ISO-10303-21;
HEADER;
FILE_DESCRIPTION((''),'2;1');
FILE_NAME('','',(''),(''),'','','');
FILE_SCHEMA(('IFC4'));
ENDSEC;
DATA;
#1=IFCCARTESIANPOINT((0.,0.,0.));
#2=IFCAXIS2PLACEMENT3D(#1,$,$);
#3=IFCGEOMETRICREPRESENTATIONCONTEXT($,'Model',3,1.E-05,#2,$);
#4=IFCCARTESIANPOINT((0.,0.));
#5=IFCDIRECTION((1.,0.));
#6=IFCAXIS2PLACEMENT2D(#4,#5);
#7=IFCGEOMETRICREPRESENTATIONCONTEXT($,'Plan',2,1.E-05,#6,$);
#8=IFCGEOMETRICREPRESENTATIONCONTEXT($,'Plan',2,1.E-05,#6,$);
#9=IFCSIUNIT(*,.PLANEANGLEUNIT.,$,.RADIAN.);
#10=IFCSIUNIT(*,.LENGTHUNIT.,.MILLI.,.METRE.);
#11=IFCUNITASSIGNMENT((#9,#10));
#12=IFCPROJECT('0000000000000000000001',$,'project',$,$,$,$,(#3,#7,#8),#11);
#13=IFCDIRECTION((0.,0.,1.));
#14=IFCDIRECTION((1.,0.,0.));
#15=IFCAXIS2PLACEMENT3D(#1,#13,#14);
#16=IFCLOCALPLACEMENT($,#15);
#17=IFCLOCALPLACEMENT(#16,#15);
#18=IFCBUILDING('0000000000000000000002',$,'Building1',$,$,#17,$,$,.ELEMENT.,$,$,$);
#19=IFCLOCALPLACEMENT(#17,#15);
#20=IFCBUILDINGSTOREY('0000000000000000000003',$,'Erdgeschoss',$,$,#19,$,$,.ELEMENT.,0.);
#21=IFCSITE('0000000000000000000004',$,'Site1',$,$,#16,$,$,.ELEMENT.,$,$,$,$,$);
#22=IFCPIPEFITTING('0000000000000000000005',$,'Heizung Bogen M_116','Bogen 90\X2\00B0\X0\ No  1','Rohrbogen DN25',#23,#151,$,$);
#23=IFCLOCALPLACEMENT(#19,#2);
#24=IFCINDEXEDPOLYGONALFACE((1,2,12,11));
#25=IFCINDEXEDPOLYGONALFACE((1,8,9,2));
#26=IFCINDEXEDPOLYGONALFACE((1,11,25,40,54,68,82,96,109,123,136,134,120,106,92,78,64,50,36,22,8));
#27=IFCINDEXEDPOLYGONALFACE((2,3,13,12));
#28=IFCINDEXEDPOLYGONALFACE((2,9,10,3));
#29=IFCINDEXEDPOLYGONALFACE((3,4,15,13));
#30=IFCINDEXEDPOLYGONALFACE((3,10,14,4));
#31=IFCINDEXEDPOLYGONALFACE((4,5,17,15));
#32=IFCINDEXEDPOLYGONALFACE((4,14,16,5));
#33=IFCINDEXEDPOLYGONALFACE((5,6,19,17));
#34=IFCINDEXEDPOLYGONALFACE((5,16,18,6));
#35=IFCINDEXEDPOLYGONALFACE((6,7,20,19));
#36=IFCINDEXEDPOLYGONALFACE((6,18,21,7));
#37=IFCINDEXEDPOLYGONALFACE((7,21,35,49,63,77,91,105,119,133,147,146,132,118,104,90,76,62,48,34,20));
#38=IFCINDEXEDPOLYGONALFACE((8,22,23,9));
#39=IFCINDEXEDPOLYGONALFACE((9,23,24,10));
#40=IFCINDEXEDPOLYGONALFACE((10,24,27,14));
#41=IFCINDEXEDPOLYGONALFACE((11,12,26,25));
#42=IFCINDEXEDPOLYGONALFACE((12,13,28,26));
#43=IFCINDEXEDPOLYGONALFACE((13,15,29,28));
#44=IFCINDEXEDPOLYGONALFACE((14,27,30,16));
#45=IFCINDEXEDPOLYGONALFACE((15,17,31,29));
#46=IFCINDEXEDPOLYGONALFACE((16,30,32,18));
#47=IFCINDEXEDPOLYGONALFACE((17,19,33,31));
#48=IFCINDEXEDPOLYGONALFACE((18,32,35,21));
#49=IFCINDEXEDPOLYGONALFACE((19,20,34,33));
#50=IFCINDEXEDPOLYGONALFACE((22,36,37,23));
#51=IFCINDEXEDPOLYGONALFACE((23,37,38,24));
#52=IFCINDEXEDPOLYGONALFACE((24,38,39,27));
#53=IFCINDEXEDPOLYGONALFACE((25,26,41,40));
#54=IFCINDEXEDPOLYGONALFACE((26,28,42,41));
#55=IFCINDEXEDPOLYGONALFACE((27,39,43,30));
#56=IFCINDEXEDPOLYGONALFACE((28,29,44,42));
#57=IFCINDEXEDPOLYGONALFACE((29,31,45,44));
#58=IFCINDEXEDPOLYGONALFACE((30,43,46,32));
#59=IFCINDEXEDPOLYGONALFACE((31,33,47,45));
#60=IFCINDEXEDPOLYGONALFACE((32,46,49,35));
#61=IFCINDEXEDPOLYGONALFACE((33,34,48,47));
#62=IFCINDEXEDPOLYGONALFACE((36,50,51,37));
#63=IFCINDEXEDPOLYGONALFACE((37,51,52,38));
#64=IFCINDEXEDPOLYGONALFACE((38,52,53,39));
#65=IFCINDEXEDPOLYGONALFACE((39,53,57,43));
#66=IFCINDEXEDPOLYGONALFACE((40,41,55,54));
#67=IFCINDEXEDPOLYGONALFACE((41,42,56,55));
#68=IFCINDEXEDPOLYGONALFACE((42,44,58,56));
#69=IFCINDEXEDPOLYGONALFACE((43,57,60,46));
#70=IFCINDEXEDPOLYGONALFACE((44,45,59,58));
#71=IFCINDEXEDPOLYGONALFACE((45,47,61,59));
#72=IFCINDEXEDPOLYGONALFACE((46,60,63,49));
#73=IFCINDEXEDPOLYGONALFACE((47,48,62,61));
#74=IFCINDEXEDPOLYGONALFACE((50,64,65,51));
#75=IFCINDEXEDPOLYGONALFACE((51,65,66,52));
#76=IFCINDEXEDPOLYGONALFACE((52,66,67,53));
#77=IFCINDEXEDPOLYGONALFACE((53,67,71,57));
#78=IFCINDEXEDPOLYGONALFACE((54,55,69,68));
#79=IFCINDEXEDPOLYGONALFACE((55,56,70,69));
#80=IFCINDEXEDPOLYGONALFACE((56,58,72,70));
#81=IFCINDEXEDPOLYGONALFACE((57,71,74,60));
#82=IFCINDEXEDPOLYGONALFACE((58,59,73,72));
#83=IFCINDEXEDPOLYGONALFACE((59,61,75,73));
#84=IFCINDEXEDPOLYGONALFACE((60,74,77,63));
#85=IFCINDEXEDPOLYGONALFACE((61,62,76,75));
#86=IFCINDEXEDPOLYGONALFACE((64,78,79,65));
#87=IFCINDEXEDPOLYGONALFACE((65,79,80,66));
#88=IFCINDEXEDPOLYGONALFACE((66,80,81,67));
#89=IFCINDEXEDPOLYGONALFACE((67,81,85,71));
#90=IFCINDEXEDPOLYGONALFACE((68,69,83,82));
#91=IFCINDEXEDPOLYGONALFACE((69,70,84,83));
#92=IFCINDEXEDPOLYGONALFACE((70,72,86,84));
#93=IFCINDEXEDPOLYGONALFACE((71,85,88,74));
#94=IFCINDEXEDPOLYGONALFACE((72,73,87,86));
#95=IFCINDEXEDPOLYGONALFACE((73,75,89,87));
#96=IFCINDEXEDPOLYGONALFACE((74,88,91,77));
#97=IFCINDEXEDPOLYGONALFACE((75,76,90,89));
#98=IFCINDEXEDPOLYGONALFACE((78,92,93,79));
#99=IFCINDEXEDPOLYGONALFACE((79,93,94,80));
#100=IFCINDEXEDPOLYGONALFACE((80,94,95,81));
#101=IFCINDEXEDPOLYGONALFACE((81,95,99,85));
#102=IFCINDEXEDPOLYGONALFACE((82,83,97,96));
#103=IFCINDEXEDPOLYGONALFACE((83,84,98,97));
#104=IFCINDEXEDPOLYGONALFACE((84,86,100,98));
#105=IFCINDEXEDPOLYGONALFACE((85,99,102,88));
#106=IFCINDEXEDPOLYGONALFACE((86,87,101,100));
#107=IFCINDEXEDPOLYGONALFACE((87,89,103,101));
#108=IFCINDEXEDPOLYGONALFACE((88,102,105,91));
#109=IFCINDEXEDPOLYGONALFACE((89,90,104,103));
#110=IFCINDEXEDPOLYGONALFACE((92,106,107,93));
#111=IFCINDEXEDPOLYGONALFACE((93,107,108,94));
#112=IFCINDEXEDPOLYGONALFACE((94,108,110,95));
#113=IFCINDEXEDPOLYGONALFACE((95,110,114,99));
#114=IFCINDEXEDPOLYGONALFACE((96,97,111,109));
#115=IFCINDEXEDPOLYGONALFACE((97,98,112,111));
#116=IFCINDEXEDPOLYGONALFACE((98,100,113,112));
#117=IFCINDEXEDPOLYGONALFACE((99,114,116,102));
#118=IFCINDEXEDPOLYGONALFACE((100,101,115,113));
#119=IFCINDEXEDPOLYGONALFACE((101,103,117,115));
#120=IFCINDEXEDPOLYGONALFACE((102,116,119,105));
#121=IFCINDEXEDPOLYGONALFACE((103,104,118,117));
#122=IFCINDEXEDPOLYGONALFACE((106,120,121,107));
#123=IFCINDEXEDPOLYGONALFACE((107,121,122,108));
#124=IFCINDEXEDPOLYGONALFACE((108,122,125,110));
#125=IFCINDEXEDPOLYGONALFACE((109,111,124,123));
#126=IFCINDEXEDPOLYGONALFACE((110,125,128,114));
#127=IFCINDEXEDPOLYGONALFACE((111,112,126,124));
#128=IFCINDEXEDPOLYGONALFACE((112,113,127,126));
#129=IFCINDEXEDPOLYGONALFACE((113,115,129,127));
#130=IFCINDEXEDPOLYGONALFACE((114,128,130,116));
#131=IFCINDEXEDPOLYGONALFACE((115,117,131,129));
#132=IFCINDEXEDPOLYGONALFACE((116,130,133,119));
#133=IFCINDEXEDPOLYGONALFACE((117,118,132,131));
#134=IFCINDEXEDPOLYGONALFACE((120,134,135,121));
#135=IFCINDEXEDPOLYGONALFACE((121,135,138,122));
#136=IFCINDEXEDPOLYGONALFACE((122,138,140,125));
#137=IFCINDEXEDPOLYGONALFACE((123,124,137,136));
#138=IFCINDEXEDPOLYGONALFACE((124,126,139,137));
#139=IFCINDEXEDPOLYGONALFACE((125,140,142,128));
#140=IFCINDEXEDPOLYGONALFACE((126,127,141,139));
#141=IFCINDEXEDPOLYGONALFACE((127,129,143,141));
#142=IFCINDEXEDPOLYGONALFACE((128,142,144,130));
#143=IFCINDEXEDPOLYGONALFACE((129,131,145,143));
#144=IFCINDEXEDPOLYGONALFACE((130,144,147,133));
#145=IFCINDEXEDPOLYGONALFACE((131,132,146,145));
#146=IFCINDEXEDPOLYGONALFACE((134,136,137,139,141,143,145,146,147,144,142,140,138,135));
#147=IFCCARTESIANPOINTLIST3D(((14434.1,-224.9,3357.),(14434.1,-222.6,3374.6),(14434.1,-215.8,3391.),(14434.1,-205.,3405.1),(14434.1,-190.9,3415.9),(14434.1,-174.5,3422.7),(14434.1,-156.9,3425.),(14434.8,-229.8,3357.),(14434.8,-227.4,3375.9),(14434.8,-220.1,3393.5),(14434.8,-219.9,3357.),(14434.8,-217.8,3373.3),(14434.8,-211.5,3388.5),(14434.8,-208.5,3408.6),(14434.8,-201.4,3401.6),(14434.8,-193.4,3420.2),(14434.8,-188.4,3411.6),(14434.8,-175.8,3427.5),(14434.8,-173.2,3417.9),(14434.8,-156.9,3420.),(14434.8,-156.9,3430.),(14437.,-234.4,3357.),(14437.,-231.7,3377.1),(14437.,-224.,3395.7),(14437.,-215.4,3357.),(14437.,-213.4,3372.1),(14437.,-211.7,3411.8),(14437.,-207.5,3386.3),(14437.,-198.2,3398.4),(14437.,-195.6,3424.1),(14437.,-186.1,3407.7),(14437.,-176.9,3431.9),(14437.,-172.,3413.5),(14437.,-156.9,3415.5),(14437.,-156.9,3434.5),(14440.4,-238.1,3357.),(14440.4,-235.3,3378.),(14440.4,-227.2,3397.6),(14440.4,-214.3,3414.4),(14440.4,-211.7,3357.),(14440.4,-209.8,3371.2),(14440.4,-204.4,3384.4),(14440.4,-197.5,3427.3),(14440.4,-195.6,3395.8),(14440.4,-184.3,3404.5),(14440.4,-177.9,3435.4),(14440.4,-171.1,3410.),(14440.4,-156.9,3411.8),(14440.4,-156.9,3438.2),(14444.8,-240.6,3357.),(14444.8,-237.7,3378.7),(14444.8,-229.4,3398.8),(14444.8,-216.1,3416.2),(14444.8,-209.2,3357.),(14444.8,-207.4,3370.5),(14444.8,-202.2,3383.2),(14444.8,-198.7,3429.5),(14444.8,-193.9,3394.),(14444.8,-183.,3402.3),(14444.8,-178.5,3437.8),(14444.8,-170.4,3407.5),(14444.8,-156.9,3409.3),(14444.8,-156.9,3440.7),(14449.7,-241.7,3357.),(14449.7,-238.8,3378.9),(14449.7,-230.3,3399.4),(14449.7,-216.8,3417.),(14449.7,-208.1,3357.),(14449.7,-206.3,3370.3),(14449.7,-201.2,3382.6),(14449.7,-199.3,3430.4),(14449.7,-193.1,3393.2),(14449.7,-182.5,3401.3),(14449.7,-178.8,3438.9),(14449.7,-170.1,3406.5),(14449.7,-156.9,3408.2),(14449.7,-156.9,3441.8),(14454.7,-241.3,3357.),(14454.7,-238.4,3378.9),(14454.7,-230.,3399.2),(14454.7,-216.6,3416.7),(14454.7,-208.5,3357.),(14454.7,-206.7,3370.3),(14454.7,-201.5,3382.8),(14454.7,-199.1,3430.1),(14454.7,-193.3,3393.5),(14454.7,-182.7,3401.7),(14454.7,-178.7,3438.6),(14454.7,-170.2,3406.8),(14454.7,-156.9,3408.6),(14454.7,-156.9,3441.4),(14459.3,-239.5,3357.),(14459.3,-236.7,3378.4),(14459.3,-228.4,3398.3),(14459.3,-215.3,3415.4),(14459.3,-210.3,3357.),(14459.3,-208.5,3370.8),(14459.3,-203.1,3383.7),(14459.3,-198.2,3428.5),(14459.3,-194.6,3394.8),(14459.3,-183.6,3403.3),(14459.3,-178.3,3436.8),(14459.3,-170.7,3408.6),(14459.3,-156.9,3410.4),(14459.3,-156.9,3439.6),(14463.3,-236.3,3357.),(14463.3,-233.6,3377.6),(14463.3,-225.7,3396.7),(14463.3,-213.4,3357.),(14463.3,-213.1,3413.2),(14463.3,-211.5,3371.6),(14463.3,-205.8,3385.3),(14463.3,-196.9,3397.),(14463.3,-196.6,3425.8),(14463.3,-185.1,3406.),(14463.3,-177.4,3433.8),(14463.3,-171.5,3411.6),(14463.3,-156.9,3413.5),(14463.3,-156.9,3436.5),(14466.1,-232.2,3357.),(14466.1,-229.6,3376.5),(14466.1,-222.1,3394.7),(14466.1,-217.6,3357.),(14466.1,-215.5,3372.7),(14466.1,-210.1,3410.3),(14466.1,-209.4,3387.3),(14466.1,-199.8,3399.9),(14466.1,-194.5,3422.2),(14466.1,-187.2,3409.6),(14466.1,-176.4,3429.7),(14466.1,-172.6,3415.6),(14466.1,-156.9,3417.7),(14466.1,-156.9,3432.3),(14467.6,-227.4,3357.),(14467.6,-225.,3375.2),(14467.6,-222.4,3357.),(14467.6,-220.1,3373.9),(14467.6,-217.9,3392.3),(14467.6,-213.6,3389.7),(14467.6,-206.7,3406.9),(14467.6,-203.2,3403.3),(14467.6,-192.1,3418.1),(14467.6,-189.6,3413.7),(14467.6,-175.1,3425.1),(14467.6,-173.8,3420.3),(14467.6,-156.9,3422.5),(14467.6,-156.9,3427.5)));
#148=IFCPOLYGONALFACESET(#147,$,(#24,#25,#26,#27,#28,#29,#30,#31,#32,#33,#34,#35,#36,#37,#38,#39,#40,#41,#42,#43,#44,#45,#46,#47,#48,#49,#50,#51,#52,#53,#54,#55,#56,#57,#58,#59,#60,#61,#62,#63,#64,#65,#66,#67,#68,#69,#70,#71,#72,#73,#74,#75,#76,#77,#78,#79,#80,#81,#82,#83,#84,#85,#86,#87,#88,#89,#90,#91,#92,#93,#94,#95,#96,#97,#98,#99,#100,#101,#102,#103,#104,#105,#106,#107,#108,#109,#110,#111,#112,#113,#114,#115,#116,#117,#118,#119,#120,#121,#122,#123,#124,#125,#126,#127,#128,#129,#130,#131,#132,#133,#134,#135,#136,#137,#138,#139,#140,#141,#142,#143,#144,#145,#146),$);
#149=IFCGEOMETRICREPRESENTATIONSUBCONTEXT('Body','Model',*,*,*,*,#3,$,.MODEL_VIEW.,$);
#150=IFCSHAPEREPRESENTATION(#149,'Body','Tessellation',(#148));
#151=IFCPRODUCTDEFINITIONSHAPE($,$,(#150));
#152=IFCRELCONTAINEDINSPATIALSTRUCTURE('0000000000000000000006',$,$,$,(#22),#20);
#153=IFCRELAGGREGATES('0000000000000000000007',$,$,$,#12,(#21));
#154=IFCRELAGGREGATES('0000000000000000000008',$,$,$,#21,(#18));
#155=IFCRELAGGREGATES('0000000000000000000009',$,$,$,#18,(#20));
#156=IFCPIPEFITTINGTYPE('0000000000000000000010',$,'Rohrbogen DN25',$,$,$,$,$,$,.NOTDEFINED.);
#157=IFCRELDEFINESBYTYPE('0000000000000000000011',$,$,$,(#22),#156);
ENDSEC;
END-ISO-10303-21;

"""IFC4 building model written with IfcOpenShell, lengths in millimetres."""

from ifc_helpers import new_model, entity, si_unit, frame, origin, origin_with_axes, origin_2d_with_axis, place, context, subcontext, project, spatial, shape, source, transform, mapped, type_object, element, save


model = new_model("IFC4")

# Units and contexts
model_context = context("Model", 3, precision=1e-05, world=origin())
plan_context_1 = context("Plan", 2, precision=1e-05, world=origin_2d_with_axis())
plan_context_2 = context("Plan", 2, precision=1e-05, world=origin_2d_with_axis())
body_context = subcontext(model_context, "Body", "Model", "MODEL_VIEW")
ifc_project = project(units=[si_unit("PLANEANGLEUNIT", "RADIAN"), si_unit("LENGTHUNIT", "METRE", prefix="MILLI")], contexts=[model_context, plan_context_1, plan_context_2])

# Site, building, storey
site_placement = place(None, origin_with_axes())
site = spatial("IfcSite", under=ifc_project, at=site_placement, Name="Site1", CompositionType="ELEMENT")
building_placement = place(site_placement, origin_with_axes())
building = spatial("IfcBuilding", under=site, at=building_placement, Name="Building1", CompositionType="ELEMENT")
storey_placement = place(building_placement, origin_with_axes())
storey = spatial("IfcBuildingStorey", under=building, at=storey_placement, Name="Erdgeschoss", CompositionType="ELEMENT", Elevation=0.0)

# Pipe fitting
pipe_fitting_type = type_object("IfcPipeFittingType", Name="Rohrbogen DN25", PredefinedType="NOTDEFINED")
shared_shape_1 = source(origin_with_axes(), body_context, "Body", "SolidModel", [
    entity("IfcRevolvedAreaSolid", entity("IfcCircleProfileDef", "AREA", None, entity("IfcAxis2Placement2D", entity("IfcCartesianPoint", [0.0, 0.0]), entity("IfcDirection", [1.0, 0.0])), 16.9), entity("IfcAxis2Placement3D", entity("IfcCartesianPoint", [-42.4, 0.0, 25.6]), entity("IfcDirection", [1.0, 0.0, 0.0]), entity("IfcDirection", [0.0, -1.0, 0.0])), entity("IfcAxis1Placement", entity("IfcCartesianPoint", [0.0, 68.0, 0.0]), entity("IfcDirection", [-1.0, 0.0, 0.0])), 1.570796),
])
pipe_fitting_1_placement = place(storey_placement, frame((14450.9, -199.3, 3399.4), z_axis=(0.0, 0.0, 1.0), x_axis=(1.0, 0.0, 0.0)))
element("IfcPipeFitting", 1, at=pipe_fitting_1_placement, inside=storey, type_object=pipe_fitting_type, Name="Heizung Bogen M_116", Description="Bogen 90° No  1", ObjectType="Rohrbogen DN25", shapes=[
    shape(body_context, "Body", "MappedRepresentation", [mapped(shared_shape_1, transform((0.0, 0.0, 0.0), x_axis=(0.0, -1.0, 0.0), y_axis=(1.0, 0.0, 0.0), z_axis=(0.0, 0.0, 1.0), scale=1.0))]),
    shape(body_context, "Body", "MappedRepresentation", [mapped(shared_shape_1, transform((0.0, 0.0, 0.0), x_axis=(0.0, -1.0, 0.0), y_axis=(1.0, 0.0, 0.0), z_axis=(0.0, 0.0, 1.0), scale=1.0))]),
])

save(model, "model.ifc")
